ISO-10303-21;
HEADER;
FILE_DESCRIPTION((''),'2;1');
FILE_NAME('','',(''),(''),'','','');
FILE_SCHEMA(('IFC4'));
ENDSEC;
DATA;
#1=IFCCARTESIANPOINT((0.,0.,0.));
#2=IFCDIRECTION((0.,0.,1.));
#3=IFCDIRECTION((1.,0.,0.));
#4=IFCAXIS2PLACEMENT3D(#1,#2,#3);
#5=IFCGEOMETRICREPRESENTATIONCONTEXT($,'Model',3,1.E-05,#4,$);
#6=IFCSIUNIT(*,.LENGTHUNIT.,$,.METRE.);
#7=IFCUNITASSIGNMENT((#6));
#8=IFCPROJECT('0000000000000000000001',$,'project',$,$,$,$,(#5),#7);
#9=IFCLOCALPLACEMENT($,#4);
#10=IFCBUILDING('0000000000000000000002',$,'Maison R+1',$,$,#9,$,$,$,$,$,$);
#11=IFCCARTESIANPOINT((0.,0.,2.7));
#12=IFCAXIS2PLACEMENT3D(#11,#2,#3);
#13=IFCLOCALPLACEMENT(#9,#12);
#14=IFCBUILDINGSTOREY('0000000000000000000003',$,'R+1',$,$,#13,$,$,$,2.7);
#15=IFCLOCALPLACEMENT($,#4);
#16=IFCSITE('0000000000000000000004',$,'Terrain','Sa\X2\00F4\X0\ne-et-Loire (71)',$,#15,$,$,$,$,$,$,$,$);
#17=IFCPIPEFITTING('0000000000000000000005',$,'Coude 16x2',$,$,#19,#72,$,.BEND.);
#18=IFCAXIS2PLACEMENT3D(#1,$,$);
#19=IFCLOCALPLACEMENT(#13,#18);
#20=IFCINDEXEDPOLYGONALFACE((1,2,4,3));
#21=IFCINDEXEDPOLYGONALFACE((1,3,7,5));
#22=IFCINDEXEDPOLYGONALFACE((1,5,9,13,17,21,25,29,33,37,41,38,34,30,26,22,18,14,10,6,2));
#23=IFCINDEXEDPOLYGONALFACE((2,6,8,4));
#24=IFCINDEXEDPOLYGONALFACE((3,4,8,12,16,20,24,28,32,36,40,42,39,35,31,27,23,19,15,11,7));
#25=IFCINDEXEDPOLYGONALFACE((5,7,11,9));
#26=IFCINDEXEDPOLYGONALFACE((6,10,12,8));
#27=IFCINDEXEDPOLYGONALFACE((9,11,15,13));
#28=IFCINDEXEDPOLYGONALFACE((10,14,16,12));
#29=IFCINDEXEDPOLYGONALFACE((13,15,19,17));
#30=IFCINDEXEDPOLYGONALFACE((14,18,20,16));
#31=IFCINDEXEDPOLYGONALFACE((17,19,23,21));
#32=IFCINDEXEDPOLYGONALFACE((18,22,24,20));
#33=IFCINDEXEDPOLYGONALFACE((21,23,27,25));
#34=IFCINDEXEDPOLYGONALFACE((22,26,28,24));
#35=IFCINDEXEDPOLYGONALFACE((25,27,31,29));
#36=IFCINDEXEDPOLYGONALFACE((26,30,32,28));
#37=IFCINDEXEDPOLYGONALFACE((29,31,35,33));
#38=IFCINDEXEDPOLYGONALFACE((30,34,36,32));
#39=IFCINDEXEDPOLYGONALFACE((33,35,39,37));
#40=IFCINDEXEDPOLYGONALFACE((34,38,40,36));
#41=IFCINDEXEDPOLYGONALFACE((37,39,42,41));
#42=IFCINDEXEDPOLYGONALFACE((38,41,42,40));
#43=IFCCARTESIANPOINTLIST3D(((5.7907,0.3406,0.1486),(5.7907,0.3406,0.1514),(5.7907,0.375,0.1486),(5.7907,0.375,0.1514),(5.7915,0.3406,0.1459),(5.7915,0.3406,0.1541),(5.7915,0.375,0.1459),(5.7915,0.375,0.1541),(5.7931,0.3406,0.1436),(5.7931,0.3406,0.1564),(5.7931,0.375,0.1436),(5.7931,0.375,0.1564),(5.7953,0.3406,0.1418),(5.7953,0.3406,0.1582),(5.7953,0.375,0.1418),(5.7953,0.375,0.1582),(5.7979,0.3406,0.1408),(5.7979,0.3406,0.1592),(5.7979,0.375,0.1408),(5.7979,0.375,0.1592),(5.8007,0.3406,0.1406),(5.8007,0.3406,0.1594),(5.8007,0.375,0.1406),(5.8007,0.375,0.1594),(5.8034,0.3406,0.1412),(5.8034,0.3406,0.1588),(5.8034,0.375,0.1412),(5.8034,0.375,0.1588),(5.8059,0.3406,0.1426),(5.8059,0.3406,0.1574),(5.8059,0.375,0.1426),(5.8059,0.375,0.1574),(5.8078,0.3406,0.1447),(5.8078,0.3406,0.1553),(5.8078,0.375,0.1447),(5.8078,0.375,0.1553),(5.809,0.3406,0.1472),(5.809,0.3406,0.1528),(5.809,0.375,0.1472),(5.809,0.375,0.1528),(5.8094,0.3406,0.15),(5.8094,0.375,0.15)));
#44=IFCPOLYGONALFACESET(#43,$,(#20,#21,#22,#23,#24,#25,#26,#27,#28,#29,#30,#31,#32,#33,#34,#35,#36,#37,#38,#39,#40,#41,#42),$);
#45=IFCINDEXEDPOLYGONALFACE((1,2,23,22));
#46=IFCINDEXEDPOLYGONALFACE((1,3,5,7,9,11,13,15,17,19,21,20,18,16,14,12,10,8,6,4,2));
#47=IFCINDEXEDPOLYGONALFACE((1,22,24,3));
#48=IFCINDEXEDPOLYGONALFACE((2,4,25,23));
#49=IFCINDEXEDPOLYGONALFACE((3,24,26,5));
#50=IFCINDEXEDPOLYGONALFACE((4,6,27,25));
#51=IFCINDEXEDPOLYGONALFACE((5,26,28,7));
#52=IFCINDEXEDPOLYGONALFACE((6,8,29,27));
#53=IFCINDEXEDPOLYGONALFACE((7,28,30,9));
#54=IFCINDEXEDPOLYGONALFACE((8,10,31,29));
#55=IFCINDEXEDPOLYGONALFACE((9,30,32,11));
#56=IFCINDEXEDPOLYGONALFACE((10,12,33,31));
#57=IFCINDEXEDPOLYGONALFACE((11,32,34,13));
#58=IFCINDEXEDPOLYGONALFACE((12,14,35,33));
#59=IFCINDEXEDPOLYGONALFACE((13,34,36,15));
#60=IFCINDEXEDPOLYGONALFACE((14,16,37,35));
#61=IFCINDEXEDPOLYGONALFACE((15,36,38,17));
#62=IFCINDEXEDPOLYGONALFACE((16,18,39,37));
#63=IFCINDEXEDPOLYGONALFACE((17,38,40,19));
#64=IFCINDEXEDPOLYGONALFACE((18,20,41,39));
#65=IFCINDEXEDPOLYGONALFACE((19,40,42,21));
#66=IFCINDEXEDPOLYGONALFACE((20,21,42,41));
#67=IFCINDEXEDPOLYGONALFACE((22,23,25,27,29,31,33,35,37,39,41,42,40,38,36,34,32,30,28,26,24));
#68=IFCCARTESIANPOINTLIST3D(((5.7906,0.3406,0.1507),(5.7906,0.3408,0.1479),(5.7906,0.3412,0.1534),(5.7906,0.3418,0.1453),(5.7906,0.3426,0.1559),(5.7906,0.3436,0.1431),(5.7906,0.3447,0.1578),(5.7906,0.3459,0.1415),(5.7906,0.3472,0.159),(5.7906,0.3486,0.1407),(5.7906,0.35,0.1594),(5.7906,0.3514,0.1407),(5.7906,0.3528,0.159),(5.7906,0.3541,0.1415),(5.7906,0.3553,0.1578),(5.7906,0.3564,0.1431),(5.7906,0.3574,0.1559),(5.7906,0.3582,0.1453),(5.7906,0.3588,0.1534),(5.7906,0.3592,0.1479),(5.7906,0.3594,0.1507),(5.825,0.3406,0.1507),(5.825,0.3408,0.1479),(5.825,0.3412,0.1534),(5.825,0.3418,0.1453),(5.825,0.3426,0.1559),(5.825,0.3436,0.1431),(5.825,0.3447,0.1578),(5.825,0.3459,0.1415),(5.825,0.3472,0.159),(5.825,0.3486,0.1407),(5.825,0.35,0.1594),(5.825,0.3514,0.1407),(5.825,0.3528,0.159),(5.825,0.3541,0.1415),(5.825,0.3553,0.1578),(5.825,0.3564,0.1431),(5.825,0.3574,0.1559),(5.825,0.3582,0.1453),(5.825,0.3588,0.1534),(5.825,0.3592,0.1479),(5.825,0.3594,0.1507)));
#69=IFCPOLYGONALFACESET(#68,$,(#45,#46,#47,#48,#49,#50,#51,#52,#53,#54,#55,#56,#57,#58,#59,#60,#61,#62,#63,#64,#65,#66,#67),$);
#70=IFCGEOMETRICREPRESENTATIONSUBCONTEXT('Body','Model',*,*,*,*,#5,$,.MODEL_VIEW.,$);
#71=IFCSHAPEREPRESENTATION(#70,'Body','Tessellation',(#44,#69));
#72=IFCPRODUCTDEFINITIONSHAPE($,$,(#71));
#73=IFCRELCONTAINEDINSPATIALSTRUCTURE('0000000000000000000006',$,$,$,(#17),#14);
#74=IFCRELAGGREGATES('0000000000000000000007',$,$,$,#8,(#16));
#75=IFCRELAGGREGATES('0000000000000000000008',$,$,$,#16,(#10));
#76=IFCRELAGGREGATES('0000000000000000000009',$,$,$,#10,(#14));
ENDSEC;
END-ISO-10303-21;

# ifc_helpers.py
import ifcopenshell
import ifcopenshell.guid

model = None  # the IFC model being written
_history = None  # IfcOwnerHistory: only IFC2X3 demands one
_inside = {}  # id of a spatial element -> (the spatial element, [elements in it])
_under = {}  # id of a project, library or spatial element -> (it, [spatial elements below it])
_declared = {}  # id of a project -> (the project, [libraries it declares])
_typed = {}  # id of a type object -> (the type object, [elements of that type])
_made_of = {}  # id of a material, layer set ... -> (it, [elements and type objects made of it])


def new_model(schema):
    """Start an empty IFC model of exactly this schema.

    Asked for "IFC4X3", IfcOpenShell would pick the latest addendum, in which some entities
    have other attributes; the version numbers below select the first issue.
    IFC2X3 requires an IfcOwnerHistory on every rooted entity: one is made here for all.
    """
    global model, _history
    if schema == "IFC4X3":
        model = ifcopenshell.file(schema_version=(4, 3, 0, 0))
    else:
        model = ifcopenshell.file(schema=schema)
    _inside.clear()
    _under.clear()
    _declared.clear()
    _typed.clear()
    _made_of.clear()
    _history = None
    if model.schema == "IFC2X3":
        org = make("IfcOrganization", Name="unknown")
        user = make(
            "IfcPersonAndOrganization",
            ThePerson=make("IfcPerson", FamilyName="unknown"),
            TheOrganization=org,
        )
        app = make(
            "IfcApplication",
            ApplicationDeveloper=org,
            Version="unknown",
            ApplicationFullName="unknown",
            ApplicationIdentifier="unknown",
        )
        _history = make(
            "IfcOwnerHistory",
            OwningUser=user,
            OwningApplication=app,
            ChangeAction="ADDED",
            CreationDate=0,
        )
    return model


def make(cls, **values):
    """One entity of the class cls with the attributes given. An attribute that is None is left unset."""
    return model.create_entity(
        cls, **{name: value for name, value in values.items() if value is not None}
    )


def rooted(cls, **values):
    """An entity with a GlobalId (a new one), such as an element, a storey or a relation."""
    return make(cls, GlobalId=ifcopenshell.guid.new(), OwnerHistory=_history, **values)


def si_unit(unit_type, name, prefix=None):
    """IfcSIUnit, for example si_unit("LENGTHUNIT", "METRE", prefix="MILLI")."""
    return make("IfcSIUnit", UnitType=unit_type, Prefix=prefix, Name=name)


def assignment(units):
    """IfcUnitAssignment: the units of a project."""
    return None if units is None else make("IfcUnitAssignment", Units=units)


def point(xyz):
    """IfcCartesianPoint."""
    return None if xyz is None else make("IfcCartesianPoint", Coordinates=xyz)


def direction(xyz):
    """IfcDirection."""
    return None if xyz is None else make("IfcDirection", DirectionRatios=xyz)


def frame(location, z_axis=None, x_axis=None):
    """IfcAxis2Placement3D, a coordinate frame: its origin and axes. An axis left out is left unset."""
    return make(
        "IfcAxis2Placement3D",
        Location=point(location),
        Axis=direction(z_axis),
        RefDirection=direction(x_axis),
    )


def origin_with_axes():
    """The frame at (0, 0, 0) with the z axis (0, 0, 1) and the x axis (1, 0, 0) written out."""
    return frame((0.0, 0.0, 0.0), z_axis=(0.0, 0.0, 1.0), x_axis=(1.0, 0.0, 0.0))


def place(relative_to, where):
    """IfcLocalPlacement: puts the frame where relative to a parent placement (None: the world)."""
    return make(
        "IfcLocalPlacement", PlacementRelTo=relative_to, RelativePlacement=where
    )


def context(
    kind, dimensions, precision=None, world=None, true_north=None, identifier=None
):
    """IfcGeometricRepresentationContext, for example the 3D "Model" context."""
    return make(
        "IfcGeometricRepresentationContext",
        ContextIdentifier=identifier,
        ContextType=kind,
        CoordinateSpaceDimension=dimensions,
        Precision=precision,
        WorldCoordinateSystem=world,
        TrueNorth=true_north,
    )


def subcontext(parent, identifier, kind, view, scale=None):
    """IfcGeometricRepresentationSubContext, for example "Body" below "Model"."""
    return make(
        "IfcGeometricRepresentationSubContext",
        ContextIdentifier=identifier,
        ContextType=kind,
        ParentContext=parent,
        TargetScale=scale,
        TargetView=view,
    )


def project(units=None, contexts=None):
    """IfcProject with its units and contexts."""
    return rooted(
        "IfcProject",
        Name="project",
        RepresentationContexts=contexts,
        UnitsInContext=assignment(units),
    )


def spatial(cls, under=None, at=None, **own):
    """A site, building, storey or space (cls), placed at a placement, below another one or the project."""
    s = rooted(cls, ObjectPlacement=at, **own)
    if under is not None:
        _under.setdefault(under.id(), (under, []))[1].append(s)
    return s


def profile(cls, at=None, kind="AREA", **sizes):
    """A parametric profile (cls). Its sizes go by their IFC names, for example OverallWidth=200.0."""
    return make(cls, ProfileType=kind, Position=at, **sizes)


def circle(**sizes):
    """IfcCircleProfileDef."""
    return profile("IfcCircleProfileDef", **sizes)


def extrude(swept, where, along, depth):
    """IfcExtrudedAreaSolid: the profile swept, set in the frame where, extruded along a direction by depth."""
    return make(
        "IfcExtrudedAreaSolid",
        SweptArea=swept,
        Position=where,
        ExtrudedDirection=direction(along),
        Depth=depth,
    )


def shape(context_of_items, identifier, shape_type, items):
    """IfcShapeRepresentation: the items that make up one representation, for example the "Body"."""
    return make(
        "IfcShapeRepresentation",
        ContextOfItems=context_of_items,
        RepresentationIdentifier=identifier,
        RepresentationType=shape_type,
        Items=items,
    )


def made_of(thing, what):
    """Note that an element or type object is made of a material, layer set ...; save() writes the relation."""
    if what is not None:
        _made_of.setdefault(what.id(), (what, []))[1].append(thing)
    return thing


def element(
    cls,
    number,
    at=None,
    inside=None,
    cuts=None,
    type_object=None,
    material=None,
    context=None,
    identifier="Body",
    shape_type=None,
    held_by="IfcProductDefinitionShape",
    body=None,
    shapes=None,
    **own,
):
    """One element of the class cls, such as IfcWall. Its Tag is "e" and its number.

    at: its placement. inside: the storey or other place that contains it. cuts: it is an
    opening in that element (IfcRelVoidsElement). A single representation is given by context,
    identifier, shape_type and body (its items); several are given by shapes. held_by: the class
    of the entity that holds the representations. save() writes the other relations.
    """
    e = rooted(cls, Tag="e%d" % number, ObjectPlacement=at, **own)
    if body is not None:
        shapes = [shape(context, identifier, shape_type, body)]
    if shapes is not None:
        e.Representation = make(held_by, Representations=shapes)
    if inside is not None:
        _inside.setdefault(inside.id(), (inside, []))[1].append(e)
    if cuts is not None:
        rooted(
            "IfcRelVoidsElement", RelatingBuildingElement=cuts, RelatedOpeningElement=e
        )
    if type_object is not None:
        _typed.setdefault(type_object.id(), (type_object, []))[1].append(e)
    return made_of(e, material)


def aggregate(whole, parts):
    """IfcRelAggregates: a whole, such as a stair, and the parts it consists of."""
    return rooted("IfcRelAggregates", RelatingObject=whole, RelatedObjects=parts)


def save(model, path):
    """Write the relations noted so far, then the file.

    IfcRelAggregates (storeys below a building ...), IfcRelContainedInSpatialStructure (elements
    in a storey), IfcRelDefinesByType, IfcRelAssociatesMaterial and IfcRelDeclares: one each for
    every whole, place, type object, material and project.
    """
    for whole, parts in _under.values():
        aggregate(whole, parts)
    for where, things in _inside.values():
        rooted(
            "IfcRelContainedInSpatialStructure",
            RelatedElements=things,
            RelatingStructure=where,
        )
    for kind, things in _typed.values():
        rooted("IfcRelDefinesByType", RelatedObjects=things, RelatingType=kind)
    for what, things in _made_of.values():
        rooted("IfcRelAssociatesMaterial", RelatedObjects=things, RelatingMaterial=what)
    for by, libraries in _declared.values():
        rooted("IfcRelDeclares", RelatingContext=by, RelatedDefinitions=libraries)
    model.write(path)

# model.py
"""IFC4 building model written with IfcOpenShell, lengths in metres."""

from ifc_helpers import new_model, si_unit, frame, origin_with_axes, place, context, subcontext, project, spatial, circle, extrude, element, save


model = new_model("IFC4")

# Units and contexts
model_context = context("Model", 3, precision=1e-05, world=origin_with_axes())
body_context = subcontext(model_context, "Body", "Model", "MODEL_VIEW")
ifc_project = project(units=[si_unit("LENGTHUNIT", "METRE")], contexts=[model_context])

# Site, building, storey
site_placement = place(None, origin_with_axes())
site = spatial("IfcSite", under=ifc_project, at=site_placement, Name="Terrain", Description="Saône-et-Loire (71)")
building_placement = place(None, origin_with_axes())
building = spatial("IfcBuilding", under=site, at=building_placement, Name="Maison R+1")
storey_placement = place(building_placement, frame((0.0, 0.0, 2.7), z_axis=(0.0, 0.0, 1.0), x_axis=(1.0, 0.0, 0.0)))
storey = spatial("IfcBuildingStorey", under=building, at=storey_placement, Name="R+1", Elevation=2.7)

# Pipe fitting
pipe_fitting_1_placement = place(storey_placement, frame((5.8, 0.35, 0.15), z_axis=(0.0, 0.0, 1.0), x_axis=(1.0, 0.0, 0.0)))
element("IfcPipeFitting", 1, at=pipe_fitting_1_placement, inside=storey, Name="Coude 16x2", PredefinedType="BEND", context=body_context, shape_type="SweptSolid", body=[
    extrude(circle(Radius=0.0094), frame((0.0, -0.0094, 0.0), z_axis=(0.0, 1.0, 0.0), x_axis=(1.0, 0.0, 0.0)), (0.0, 0.0, 1.0), 0.0344),
    extrude(circle(Radius=0.0094), frame((-0.0094, 0.0, 0.0), z_axis=(1.0, 0.0, 0.0), x_axis=(0.0, 0.0, 1.0)), (0.0, 0.0, 1.0), 0.0344),
])

save(model, "model.ifc")
